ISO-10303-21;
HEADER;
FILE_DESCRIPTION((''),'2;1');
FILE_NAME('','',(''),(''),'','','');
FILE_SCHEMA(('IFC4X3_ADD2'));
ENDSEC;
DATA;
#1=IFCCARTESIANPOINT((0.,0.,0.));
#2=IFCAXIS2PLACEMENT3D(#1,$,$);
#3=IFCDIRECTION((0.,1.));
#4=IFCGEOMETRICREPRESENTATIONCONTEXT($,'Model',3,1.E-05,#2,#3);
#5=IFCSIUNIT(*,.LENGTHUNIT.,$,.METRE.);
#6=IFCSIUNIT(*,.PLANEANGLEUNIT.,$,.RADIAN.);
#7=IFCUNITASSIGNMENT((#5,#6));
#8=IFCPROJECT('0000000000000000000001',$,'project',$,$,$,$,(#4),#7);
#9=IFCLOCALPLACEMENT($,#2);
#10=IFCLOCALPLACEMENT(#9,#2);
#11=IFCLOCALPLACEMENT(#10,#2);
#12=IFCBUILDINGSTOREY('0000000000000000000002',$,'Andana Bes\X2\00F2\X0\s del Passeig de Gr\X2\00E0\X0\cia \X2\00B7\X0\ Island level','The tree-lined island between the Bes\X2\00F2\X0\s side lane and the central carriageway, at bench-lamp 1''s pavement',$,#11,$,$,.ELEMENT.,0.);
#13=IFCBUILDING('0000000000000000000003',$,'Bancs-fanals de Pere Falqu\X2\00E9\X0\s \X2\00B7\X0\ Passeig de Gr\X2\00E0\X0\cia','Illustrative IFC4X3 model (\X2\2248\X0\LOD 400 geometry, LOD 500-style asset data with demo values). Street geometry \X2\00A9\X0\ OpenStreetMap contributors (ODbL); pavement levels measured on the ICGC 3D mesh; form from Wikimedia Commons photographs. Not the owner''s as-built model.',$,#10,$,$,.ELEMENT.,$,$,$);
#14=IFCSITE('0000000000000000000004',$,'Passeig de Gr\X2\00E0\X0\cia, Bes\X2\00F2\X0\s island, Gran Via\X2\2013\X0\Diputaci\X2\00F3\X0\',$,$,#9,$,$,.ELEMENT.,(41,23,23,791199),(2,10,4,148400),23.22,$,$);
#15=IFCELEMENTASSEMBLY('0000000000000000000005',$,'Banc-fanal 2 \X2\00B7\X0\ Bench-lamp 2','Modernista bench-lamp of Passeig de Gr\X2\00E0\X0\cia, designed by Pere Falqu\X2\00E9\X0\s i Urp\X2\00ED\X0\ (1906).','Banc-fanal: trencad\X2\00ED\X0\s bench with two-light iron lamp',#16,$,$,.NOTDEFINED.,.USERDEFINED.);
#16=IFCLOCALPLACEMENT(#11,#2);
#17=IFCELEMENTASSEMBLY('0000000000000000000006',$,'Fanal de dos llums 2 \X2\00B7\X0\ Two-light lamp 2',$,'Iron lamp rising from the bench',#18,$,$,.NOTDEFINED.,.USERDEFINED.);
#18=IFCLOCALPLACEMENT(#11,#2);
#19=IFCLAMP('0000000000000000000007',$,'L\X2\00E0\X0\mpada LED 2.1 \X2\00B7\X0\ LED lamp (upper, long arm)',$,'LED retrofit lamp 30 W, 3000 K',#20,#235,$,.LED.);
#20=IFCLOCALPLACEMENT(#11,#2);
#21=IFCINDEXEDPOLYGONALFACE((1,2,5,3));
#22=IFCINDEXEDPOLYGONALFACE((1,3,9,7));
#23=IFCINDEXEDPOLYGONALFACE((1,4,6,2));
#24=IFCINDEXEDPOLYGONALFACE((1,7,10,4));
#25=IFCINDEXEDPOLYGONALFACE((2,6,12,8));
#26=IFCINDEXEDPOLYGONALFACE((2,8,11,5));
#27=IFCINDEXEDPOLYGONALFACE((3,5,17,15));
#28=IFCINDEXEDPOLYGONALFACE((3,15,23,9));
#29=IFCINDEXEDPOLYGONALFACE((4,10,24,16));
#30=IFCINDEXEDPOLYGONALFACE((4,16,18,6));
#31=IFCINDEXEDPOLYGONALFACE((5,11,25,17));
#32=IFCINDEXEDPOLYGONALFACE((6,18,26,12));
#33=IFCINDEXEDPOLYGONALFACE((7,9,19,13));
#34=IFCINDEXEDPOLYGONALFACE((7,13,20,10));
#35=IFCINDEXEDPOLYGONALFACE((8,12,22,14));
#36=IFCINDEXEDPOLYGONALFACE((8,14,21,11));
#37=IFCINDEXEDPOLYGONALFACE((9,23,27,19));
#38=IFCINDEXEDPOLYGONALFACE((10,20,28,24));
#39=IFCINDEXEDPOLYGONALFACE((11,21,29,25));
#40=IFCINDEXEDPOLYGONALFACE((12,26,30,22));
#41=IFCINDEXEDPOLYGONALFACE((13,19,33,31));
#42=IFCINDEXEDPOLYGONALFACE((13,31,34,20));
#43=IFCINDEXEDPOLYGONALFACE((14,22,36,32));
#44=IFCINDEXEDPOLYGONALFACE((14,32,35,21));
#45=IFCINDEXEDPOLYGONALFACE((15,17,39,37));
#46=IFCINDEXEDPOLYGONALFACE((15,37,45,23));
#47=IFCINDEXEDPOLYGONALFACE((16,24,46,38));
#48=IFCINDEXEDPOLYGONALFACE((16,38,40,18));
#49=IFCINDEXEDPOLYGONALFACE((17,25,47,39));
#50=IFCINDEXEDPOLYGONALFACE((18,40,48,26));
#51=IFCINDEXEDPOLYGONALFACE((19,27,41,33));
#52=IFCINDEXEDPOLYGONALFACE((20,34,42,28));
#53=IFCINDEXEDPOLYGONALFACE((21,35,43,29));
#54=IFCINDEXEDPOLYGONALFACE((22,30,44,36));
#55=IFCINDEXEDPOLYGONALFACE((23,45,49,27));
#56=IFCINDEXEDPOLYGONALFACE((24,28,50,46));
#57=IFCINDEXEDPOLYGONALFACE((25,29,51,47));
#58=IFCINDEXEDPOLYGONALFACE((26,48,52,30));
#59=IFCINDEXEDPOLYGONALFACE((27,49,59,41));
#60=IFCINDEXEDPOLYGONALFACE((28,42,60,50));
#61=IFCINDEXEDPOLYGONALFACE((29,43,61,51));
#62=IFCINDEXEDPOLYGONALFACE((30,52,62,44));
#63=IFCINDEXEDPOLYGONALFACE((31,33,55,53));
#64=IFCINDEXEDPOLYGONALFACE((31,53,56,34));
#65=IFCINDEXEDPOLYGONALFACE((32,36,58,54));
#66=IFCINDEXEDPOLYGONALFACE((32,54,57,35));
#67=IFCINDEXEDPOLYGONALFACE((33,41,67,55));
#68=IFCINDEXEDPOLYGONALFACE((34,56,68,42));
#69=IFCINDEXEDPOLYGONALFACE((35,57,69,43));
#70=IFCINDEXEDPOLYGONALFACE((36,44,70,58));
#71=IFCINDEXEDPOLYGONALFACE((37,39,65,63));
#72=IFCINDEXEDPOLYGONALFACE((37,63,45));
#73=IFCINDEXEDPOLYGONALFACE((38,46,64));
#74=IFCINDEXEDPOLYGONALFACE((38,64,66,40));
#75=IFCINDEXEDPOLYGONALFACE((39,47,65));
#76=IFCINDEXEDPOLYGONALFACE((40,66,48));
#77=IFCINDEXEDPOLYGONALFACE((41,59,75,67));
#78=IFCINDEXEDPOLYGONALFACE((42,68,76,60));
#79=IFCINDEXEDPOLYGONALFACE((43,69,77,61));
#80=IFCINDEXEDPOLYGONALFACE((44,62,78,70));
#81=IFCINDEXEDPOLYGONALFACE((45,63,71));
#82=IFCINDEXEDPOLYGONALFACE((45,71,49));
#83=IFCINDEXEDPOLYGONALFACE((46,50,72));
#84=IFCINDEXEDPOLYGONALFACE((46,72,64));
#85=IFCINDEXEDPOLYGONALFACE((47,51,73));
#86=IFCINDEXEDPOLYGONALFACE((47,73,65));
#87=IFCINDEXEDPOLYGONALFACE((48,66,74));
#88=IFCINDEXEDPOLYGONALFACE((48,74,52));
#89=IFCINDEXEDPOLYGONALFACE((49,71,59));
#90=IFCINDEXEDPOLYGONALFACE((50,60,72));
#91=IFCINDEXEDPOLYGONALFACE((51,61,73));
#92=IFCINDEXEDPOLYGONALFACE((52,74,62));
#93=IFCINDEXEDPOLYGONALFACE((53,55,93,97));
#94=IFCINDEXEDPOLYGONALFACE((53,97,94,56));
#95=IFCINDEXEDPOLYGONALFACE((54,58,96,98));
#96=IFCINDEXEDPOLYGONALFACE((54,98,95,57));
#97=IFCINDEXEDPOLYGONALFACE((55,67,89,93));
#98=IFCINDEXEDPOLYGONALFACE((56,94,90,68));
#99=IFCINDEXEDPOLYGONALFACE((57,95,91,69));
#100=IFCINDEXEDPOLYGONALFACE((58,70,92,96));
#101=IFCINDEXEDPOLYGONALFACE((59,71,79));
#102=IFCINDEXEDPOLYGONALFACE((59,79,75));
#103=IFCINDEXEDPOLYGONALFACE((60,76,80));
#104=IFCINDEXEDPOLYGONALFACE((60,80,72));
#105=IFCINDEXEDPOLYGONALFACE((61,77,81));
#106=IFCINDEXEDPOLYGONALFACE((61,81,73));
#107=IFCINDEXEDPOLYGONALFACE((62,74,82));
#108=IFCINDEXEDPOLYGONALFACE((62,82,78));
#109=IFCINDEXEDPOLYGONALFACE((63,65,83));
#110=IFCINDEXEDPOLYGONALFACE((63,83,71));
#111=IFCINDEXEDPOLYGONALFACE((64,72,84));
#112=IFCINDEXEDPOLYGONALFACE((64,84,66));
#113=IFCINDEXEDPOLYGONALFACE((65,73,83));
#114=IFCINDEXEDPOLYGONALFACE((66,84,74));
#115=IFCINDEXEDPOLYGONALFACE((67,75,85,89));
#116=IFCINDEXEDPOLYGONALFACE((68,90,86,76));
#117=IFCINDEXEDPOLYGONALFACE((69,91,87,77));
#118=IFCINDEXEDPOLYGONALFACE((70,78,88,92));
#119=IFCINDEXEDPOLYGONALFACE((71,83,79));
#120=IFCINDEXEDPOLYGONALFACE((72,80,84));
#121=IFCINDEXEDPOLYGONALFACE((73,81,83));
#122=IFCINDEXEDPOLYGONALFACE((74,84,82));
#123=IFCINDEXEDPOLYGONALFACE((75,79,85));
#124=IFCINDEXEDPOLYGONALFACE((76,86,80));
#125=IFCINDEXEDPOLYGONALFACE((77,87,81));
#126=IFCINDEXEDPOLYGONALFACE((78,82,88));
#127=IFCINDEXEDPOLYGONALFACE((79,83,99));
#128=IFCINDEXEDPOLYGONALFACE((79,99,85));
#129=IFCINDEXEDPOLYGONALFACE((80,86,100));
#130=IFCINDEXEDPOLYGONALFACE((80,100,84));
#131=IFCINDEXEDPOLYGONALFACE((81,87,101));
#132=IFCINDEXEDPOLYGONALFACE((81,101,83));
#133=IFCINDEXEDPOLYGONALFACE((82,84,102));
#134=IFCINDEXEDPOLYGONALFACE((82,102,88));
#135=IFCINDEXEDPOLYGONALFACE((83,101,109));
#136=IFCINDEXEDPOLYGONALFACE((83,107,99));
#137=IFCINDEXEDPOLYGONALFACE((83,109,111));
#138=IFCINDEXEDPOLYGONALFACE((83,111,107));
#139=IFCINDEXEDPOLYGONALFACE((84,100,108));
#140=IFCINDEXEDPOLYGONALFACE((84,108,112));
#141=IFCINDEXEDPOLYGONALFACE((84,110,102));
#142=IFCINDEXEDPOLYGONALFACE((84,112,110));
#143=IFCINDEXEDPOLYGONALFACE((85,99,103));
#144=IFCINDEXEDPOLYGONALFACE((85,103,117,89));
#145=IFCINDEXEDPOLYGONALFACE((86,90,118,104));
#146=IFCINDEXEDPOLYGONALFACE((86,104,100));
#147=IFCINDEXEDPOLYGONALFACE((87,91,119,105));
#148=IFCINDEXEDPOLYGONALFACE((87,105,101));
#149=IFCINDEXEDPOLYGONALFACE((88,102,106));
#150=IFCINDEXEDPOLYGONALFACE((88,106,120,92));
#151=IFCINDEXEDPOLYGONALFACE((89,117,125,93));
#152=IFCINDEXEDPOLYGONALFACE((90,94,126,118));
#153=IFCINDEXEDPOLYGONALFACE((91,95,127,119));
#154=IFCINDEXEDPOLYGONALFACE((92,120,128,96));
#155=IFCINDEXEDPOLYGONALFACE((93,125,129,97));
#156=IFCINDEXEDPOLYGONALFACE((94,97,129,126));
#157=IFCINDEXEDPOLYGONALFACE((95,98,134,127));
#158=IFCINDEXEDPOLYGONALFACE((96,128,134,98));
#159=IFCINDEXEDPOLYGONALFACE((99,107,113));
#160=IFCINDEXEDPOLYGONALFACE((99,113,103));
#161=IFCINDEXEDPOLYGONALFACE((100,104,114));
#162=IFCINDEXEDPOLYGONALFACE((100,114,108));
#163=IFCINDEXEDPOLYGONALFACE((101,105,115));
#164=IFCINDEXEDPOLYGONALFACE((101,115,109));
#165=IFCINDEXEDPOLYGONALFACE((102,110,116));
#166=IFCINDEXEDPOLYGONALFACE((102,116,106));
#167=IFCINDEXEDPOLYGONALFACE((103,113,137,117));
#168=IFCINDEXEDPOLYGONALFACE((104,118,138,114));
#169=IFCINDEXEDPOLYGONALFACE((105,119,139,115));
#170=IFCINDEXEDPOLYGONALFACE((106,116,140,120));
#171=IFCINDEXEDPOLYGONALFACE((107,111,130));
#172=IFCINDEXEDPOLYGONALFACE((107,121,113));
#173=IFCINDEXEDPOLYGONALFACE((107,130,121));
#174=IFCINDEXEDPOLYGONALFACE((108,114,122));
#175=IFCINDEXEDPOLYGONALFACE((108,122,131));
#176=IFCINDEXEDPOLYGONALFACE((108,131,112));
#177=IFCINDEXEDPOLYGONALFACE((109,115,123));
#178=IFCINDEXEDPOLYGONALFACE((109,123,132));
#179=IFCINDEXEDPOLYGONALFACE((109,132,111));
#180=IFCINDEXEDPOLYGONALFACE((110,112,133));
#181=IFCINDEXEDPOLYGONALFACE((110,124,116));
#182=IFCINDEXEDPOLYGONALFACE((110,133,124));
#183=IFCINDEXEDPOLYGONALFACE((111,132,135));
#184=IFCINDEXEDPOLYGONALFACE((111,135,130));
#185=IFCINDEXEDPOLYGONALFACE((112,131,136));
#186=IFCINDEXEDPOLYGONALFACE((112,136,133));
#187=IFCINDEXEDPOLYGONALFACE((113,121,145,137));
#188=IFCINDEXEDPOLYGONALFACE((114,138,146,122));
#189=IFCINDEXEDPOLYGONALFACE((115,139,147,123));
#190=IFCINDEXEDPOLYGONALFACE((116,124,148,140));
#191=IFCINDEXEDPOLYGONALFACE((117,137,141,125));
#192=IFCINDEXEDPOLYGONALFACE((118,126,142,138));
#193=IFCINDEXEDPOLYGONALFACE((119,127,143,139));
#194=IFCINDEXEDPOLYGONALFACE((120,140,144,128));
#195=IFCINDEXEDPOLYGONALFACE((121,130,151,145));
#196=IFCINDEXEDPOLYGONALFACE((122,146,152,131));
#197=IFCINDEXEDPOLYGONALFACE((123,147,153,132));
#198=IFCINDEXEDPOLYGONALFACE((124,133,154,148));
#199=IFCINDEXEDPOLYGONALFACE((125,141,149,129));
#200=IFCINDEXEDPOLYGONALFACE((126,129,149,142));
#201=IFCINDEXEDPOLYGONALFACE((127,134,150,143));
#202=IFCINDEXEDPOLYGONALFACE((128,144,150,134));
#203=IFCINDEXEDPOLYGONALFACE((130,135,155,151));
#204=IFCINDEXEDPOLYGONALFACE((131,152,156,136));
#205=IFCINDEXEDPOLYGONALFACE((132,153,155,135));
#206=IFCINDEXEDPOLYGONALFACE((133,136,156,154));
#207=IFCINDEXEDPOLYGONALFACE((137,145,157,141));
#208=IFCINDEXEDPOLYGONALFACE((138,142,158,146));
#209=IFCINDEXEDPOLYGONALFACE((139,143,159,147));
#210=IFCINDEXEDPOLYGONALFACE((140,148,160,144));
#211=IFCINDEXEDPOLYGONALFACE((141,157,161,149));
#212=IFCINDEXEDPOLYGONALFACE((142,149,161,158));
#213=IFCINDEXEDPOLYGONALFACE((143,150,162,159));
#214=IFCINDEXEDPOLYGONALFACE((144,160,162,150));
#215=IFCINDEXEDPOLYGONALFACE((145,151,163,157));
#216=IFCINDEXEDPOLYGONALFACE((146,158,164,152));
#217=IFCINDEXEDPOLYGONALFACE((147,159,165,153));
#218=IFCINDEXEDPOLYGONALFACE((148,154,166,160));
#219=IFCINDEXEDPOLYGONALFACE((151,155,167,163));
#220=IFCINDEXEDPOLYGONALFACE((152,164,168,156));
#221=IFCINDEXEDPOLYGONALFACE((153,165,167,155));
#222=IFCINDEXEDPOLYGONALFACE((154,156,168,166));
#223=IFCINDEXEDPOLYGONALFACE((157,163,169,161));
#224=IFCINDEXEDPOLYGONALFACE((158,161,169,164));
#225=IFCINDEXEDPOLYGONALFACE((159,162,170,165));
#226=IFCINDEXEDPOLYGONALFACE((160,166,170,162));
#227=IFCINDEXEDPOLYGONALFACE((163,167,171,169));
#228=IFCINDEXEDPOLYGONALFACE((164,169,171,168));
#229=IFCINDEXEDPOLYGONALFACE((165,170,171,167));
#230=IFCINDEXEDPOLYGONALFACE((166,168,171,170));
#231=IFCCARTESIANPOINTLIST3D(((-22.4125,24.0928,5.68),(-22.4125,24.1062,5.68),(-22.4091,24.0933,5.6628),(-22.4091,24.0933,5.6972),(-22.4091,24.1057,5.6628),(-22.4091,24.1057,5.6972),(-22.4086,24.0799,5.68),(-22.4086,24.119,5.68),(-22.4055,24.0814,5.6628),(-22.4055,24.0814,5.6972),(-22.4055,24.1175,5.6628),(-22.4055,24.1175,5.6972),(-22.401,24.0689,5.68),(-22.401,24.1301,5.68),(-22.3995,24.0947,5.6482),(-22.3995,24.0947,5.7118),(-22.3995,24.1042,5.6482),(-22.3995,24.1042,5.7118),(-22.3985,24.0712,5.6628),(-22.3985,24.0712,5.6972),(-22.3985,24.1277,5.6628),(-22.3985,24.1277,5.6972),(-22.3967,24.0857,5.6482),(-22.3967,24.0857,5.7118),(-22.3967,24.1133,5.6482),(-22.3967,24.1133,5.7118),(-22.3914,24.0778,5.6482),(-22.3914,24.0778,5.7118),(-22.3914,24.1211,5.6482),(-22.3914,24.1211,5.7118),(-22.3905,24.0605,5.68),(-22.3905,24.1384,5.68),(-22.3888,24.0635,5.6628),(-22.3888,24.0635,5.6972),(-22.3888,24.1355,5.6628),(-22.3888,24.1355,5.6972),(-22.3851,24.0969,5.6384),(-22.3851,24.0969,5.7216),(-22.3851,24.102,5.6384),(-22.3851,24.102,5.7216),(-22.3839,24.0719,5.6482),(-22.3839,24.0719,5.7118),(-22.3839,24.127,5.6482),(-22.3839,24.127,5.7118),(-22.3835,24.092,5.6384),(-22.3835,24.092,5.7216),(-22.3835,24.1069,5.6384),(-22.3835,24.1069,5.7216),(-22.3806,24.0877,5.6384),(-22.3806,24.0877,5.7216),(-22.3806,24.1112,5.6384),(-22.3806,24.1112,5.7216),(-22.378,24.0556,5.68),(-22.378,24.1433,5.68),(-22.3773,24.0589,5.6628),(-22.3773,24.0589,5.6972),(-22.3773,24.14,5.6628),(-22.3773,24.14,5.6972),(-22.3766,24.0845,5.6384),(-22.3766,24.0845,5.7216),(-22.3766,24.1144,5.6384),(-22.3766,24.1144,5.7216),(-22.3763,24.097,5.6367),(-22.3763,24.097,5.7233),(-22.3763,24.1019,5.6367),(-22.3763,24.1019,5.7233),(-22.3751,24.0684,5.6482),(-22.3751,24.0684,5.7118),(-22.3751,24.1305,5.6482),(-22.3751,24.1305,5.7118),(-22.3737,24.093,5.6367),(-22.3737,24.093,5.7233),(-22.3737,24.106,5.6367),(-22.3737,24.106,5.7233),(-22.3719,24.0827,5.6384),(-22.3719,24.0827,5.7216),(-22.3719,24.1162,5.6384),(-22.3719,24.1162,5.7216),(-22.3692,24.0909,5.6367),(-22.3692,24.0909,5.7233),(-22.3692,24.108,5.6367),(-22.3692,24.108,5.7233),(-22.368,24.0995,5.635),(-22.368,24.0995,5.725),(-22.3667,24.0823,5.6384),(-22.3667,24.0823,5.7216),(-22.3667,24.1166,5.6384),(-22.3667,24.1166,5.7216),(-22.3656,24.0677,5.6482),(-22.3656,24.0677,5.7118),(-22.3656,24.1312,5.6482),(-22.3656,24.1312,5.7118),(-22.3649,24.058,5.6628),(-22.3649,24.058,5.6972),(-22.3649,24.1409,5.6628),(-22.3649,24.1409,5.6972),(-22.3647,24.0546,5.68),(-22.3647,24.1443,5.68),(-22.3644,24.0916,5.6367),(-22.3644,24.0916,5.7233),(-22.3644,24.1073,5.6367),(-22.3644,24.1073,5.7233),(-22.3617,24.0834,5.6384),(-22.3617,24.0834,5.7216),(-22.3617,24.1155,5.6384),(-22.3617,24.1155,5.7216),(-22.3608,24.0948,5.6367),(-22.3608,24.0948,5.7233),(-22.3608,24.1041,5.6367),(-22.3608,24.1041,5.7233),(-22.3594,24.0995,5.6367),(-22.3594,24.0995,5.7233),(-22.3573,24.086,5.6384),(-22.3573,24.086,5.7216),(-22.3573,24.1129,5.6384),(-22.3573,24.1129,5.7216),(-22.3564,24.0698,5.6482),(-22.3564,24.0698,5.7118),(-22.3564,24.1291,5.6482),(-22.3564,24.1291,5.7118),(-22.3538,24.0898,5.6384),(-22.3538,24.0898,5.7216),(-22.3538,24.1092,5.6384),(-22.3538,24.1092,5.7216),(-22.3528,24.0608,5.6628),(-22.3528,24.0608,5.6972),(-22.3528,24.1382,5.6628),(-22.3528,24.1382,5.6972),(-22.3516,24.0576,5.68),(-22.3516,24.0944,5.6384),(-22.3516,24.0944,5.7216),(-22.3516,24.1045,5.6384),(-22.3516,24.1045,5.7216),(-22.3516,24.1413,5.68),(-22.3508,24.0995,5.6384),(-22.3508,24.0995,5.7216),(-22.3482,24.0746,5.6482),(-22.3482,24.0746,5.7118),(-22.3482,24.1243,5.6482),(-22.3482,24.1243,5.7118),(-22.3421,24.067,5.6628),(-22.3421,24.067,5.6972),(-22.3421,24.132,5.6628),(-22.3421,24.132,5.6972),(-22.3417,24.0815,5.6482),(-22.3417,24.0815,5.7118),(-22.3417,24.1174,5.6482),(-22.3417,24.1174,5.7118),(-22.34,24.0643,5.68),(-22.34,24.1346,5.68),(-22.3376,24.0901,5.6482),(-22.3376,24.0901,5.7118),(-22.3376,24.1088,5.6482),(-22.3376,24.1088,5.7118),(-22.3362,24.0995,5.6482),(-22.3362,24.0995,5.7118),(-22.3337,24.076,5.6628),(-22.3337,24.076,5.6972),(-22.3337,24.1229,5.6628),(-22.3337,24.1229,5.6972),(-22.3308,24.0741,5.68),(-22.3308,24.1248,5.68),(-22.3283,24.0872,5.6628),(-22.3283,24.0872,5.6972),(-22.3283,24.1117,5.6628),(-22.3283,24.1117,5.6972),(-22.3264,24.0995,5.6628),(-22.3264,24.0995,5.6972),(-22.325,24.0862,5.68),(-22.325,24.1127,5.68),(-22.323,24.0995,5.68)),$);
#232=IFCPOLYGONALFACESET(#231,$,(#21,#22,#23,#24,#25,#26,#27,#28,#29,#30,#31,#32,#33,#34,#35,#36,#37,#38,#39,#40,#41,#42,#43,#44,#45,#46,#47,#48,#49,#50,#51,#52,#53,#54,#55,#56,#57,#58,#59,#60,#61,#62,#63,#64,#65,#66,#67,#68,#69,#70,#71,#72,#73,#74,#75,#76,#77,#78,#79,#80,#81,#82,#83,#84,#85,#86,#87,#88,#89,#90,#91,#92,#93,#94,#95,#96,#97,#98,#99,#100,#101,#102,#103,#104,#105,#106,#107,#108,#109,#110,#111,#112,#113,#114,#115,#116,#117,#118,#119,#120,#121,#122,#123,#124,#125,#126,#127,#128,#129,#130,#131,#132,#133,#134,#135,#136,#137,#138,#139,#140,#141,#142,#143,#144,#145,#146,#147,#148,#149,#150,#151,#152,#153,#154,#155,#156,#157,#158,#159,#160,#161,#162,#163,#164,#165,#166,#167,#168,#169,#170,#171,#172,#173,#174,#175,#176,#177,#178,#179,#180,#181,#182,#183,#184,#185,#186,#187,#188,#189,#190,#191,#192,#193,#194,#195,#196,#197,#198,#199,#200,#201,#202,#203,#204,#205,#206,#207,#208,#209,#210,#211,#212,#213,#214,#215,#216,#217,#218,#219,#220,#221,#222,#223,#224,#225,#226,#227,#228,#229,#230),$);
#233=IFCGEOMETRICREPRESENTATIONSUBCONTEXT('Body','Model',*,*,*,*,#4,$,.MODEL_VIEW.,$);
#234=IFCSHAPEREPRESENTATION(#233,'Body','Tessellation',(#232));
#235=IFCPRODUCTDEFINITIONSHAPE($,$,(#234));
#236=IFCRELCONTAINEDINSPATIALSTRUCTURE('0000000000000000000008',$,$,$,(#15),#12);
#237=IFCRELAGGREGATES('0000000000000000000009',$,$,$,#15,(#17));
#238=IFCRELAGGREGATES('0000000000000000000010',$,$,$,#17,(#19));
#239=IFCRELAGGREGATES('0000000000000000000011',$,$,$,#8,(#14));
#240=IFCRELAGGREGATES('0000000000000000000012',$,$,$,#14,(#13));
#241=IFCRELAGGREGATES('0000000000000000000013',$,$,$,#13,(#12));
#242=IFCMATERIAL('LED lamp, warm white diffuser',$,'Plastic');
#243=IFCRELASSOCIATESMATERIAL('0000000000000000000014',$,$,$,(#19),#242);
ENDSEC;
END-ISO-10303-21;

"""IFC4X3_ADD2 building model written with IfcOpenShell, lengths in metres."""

from ifc_helpers import new_model, entity, si_unit, direction, origin, place, context, subcontext, project, spatial, material, element, aggregate, save


model = new_model("IFC4X3_ADD2")

# Units and contexts
model_context = context("Model", 3, precision=1e-05, world=origin(), true_north=direction((0.0, 1.0)))
body_context = subcontext(model_context, "Body", "Model", "MODEL_VIEW")
ifc_project = project(units=[si_unit("LENGTHUNIT", "METRE"), si_unit("PLANEANGLEUNIT", "RADIAN")], contexts=[model_context])

# Site, building, storey
site_placement = place(None, origin())
site = spatial("IfcSite", under=ifc_project, at=site_placement, Name="Passeig de Gràcia, Besòs island, Gran Via–Diputació", CompositionType="ELEMENT", RefLatitude=(41, 23, 23, 791199), RefLongitude=(2, 10, 4, 148400), RefElevation=23.22)
building_placement = place(site_placement, origin())
building = spatial("IfcBuilding", under=site, at=building_placement, Name="Bancs-fanals de Pere Falqués · Passeig de Gràcia", Description="Illustrative IFC4X3 model (≈LOD 400 geometry, LOD 500-style asset data with demo values). Street geometry © OpenStreetMap contributors (ODbL); pavement levels measured on the ICGC 3D mesh; form from Wikimedia Commons photographs. Not the owner's as-built model.", CompositionType="ELEMENT")
storey_placement = place(building_placement, origin())
storey = spatial("IfcBuildingStorey", under=building, at=storey_placement, Name="Andana Besòs del Passeig de Gràcia · Island level", Description="The tree-lined island between the Besòs side lane and the central carriageway, at bench-lamp 1's pavement", CompositionType="ELEMENT", Elevation=0.0)

# Element assemblies
assembly_1_placement = place(building_placement, origin())
assembly_1 = element("IfcElementAssembly", 1, at=assembly_1_placement, inside=storey, Name="Banc-fanal 2 · Bench-lamp 2", Description="Modernista bench-lamp of Passeig de Gràcia, designed by Pere Falqués i Urpí (1906).", ObjectType="Banc-fanal: trencadís bench with two-light iron lamp", AssemblyPlace="NOTDEFINED", PredefinedType="USERDEFINED")
assembly_2_placement = place(building_placement, origin())
assembly_2 = element("IfcElementAssembly", 2, at=assembly_2_placement, Name="Fanal de dos llums 2 · Two-light lamp 2", ObjectType="Iron lamp rising from the bench", AssemblyPlace="NOTDEFINED", PredefinedType="USERDEFINED")
aggregate(assembly_1, [assembly_2])

# Lamp
ifc_material_1 = material(Name="LED lamp, warm white diffuser", Category="Plastic")
lamp_1_placement = place(building_placement, origin())
lamp_1 = element("IfcLamp", 3, at=lamp_1_placement, material=ifc_material_1, Name="Làmpada LED 2.1 · LED lamp (upper, long arm)", ObjectType="LED retrofit lamp 30 W, 3000 K", PredefinedType="LED", context=body_context, shape_type="SweptSolid", body=[
    entity("IfcRevolvedAreaSolid", entity("IfcArbitraryClosedProfileDef", "AREA", None, entity("IfcPolyline", [entity("IfcCartesianPoint", [0.0, -0.045]), entity("IfcCartesianPoint", [0.0172, -0.0416]), entity("IfcCartesianPoint", [0.0318, -0.0318]), entity("IfcCartesianPoint", [0.0416, -0.0172]), entity("IfcCartesianPoint", [0.045, 0.0]), entity("IfcCartesianPoint", [0.0416, 0.0172]), entity("IfcCartesianPoint", [0.0318, 0.0318]), entity("IfcCartesianPoint", [0.0172, 0.0416]), entity("IfcCartesianPoint", [0.0, 0.045]), entity("IfcCartesianPoint", [0.0, -0.045])])), entity("IfcAxis2Placement3D", entity("IfcCartesianPoint", [-22.368, 24.0995, 5.68]), entity("IfcDirection", [0.0, -1.0, 0.0]), entity("IfcDirection", [1.0, 0.0, 0.0])), entity("IfcAxis1Placement", entity("IfcCartesianPoint", [0.0, 0.0, 0.0]), entity("IfcDirection", [0.0, 1.0, 0.0])), 6.283185),
])

aggregate(assembly_2, [lamp_1])

save(model, "model.ifc")
